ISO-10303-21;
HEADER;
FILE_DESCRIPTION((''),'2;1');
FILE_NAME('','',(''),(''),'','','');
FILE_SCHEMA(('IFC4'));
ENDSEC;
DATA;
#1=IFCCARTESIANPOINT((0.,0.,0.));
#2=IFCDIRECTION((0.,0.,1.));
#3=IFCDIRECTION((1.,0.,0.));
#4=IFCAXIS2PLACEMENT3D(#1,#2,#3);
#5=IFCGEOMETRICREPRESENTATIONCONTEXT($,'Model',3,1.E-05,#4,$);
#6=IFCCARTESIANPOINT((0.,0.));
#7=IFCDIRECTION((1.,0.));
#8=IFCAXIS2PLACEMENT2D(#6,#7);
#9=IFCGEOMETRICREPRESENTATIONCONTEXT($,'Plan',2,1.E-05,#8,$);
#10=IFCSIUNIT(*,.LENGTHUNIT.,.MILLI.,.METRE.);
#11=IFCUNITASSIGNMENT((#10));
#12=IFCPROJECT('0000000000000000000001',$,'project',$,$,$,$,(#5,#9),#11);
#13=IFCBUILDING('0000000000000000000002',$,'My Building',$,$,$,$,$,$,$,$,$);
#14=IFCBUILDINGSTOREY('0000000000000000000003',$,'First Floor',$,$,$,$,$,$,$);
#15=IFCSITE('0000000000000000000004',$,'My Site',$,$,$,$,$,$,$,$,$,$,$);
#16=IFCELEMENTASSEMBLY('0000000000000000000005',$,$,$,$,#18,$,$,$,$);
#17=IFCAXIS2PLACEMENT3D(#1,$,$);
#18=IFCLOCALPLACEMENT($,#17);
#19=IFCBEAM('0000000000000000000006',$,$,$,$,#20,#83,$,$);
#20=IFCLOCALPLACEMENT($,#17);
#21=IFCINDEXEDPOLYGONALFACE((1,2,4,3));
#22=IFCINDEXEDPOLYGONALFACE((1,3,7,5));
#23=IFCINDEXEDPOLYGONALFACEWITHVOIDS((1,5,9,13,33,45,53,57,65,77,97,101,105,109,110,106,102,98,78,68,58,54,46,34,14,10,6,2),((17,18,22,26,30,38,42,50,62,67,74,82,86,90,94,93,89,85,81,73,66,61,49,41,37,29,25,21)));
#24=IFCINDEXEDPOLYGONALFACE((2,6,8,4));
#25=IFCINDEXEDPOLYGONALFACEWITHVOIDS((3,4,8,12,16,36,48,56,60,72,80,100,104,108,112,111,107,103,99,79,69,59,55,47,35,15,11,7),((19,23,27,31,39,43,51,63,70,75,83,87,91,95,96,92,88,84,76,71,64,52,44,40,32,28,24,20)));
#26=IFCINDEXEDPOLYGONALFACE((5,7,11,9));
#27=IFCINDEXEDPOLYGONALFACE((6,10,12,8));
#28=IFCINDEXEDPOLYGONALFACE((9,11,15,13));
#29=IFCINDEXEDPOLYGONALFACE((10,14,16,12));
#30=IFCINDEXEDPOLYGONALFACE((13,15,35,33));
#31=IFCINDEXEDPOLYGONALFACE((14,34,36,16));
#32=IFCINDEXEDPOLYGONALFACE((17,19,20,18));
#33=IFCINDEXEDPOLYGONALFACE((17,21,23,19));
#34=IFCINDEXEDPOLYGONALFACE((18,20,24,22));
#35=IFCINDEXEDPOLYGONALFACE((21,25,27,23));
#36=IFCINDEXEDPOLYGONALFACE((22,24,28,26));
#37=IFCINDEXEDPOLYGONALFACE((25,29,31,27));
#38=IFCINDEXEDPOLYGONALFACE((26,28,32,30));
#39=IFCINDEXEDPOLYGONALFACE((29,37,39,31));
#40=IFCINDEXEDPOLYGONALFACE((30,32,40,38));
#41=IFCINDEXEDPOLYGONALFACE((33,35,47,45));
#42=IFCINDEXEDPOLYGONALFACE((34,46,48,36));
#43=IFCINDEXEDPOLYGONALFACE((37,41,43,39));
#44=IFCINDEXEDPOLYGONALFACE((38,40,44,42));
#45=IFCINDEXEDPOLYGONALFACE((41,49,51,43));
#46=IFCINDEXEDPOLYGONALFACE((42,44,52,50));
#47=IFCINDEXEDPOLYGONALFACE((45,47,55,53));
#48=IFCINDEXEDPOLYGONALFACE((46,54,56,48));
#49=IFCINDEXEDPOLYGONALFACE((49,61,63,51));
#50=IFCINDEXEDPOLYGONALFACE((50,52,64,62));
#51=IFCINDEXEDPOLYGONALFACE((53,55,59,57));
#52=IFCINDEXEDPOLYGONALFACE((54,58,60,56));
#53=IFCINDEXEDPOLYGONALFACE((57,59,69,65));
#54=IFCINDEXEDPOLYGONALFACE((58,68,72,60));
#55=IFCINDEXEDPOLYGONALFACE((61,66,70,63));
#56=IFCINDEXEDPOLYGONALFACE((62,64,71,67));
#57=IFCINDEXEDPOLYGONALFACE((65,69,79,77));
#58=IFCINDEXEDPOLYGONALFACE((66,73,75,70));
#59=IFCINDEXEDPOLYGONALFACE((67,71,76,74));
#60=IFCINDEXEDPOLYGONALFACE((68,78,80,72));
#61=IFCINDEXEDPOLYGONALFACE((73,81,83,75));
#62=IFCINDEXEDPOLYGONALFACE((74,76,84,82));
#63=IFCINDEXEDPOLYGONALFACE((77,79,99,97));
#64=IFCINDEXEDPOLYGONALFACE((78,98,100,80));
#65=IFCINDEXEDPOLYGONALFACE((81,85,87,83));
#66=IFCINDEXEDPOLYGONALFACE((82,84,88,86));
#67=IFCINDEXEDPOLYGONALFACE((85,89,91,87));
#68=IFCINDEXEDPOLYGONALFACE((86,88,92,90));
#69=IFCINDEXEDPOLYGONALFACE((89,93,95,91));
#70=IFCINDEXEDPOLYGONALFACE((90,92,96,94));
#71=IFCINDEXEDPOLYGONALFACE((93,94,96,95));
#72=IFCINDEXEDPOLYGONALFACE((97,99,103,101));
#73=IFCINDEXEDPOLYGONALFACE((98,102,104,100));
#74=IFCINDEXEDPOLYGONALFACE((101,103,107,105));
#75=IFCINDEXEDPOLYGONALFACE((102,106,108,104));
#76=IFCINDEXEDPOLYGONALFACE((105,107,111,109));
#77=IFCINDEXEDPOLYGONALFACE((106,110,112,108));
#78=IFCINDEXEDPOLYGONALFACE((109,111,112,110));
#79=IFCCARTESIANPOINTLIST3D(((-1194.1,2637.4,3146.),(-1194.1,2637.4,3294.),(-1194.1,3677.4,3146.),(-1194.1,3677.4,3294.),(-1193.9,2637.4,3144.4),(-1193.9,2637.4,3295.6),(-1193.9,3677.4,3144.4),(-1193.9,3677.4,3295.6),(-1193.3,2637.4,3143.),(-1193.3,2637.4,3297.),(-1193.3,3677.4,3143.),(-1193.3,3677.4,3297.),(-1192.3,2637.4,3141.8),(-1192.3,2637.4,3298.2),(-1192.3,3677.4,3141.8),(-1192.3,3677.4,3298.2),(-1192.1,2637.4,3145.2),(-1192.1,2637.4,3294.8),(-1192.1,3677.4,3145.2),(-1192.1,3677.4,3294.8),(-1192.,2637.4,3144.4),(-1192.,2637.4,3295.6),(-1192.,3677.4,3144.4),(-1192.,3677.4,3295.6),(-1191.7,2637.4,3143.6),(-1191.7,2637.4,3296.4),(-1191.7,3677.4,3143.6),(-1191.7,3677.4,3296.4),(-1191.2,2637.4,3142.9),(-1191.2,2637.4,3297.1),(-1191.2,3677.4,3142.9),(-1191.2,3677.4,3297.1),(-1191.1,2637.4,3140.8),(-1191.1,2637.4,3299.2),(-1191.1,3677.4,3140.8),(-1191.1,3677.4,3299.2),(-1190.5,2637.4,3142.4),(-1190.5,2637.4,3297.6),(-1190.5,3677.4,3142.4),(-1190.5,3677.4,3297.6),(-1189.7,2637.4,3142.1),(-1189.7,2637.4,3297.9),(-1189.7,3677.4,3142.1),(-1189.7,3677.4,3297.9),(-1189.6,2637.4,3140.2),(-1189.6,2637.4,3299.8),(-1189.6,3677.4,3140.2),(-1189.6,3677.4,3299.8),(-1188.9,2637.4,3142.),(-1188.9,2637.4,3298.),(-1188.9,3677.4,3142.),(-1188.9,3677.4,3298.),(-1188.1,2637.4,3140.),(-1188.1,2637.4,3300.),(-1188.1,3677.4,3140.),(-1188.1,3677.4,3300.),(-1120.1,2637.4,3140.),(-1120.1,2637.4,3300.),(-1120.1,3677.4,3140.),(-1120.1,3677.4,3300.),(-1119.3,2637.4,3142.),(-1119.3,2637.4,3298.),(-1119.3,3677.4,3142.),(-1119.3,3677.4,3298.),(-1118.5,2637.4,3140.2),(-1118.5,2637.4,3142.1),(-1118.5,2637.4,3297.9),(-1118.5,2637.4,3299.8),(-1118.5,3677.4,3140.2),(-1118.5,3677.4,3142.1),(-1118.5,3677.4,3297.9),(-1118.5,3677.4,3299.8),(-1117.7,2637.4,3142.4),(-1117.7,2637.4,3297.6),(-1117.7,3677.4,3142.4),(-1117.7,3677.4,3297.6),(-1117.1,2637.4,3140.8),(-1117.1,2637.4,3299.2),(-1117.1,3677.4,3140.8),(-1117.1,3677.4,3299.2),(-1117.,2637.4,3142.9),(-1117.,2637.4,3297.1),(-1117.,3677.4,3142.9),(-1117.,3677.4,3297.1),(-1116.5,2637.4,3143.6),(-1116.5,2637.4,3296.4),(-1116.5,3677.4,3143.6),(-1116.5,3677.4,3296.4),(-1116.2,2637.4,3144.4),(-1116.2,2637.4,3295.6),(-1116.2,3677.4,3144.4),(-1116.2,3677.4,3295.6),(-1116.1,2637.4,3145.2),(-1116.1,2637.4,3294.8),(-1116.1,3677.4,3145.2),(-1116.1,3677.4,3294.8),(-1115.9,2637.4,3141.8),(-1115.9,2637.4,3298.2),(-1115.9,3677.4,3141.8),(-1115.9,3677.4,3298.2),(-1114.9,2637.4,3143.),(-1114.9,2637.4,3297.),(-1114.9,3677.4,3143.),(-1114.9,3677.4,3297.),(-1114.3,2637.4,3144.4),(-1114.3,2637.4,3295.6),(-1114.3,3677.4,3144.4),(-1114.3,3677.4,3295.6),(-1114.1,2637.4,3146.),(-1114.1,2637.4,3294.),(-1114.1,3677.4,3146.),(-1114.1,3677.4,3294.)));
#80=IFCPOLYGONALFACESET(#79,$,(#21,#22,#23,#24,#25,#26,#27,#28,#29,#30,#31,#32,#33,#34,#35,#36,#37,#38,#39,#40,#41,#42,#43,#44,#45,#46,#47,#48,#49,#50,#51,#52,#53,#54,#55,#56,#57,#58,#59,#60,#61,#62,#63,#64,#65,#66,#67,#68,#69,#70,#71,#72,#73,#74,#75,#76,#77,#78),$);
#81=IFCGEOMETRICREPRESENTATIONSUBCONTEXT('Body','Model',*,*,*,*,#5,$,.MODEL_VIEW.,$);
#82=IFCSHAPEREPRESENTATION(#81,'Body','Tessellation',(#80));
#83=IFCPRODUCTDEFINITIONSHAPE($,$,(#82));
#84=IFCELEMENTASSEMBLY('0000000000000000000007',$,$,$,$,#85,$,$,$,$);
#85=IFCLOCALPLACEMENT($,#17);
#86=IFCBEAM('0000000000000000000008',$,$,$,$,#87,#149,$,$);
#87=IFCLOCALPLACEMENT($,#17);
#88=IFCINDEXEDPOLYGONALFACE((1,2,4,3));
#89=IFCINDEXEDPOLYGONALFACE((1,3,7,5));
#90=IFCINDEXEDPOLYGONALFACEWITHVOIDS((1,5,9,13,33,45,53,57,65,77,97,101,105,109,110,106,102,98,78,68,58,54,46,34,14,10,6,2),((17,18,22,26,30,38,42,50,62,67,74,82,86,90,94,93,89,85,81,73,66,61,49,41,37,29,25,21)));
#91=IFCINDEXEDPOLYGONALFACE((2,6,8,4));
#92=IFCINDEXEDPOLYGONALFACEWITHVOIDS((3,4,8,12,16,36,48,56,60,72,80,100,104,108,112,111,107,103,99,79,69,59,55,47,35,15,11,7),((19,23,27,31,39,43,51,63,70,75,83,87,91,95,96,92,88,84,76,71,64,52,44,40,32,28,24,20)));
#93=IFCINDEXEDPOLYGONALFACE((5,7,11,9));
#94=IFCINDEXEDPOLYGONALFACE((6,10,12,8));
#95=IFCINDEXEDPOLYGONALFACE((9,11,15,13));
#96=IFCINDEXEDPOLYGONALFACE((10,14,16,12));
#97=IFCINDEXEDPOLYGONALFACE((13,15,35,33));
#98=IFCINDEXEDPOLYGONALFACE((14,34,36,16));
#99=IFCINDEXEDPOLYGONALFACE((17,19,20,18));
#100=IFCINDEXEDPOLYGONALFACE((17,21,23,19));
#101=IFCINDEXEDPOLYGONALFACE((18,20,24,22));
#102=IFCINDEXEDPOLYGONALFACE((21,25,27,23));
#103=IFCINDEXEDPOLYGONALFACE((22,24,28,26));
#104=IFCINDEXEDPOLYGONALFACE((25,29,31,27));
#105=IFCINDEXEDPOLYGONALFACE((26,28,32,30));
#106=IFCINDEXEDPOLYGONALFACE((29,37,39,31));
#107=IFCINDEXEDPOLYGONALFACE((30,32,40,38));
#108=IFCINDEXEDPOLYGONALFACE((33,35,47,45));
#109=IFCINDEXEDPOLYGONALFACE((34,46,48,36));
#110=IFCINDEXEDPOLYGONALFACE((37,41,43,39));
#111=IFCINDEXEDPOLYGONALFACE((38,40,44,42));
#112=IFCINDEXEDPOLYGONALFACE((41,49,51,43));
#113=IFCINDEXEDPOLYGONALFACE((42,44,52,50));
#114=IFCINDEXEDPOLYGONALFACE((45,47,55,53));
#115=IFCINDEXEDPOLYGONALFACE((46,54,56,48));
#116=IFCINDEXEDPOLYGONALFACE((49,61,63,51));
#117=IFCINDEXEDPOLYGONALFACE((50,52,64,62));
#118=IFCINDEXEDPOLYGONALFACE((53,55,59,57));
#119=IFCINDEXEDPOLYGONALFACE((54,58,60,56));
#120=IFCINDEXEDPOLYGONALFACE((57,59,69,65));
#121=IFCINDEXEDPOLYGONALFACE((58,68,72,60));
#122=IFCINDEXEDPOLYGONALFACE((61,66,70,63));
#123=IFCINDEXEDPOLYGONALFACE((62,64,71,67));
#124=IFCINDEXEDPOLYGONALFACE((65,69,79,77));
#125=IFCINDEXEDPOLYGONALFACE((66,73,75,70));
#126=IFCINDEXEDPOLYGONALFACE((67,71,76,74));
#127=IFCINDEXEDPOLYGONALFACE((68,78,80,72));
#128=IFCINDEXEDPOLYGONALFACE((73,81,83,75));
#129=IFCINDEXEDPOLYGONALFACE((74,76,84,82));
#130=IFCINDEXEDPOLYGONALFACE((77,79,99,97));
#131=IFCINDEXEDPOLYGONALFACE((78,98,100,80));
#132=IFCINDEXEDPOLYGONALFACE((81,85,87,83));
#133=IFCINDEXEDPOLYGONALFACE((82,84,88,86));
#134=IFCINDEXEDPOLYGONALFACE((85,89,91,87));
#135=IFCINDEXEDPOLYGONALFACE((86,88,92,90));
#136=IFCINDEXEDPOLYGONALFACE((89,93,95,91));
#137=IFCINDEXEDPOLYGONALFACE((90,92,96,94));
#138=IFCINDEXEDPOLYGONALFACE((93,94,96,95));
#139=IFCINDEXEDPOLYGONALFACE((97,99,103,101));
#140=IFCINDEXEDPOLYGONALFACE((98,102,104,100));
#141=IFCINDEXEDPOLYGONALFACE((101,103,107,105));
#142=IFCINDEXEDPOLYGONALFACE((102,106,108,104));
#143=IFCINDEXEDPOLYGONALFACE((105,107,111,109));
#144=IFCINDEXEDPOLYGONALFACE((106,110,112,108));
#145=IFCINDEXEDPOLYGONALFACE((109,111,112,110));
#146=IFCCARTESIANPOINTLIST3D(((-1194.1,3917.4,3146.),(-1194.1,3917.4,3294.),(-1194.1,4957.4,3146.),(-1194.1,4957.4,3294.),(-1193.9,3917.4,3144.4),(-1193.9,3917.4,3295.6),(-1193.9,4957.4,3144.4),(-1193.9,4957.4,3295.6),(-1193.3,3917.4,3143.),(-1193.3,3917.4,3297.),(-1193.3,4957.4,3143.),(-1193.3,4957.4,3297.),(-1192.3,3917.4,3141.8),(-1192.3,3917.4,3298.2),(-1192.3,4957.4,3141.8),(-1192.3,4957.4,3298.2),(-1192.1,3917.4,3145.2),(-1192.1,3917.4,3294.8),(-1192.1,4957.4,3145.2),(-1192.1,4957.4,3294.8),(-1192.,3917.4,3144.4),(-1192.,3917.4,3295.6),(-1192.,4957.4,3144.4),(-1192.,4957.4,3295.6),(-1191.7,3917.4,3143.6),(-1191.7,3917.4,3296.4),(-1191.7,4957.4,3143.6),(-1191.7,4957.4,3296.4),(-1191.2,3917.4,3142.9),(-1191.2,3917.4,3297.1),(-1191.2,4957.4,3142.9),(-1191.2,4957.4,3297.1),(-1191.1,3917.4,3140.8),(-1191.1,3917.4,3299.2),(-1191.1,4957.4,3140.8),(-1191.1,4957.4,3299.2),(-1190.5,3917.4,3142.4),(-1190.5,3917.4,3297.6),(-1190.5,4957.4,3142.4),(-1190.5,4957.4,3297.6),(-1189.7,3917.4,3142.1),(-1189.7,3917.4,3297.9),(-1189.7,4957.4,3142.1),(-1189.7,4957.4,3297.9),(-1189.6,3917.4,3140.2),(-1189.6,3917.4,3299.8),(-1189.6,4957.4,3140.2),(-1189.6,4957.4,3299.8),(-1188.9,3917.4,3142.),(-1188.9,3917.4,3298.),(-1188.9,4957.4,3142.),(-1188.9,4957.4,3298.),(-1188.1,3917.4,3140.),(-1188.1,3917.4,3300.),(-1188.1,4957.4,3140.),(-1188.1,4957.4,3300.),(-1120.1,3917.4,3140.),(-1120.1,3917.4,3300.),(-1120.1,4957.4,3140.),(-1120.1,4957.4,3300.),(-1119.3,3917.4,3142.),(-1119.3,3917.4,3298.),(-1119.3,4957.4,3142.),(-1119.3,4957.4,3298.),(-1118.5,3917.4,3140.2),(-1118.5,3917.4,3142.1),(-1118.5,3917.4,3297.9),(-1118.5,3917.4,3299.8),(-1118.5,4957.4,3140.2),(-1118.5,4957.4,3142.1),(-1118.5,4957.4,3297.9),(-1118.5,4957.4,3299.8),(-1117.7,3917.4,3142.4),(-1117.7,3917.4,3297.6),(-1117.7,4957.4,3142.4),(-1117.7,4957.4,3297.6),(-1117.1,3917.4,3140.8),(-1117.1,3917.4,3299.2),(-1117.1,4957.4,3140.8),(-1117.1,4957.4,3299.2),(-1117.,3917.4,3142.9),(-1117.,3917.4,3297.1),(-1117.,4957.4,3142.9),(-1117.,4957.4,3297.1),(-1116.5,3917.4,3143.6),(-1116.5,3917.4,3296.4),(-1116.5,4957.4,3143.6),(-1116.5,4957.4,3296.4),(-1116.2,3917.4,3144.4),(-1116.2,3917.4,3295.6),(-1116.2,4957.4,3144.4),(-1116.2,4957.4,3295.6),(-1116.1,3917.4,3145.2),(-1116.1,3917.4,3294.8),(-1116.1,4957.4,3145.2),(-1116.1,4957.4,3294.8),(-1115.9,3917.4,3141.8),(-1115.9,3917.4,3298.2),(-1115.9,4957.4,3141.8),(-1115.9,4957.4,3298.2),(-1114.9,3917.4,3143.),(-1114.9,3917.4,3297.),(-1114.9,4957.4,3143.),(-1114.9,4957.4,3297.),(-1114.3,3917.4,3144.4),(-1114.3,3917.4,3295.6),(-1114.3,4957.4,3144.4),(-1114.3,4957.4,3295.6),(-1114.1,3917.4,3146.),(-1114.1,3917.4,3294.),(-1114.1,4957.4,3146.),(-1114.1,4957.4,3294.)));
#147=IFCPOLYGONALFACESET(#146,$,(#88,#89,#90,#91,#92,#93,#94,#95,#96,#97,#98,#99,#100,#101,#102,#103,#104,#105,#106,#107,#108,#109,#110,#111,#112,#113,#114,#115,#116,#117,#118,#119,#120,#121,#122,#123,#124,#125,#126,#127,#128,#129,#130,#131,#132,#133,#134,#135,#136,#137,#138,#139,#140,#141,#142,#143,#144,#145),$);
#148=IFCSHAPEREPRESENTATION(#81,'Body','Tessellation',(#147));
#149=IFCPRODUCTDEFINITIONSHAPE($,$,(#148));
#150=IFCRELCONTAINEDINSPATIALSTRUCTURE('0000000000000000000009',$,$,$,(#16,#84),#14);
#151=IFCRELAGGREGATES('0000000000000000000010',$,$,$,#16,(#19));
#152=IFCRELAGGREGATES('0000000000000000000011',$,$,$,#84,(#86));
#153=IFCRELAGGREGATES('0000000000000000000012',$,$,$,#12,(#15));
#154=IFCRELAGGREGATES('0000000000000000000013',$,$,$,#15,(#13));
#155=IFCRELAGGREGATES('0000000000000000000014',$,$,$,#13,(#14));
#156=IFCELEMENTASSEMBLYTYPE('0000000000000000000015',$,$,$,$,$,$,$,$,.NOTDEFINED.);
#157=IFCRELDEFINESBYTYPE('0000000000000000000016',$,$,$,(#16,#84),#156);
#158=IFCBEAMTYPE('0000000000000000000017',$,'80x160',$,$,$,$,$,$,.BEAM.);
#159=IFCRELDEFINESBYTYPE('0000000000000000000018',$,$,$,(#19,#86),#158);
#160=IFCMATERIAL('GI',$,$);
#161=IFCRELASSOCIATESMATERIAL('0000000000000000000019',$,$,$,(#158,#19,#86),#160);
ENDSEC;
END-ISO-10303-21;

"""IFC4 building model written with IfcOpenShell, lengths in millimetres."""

from ifc_helpers import new_model, si_unit, frame, origin_with_axes, origin_2d_with_axis, place, context, subcontext, project, spatial, hollow_rectangle, extrude, material, material_profile, profile_set, profile_usage, type_object, element, aggregate, save


model = new_model("IFC4")

# Units and contexts
model_context = context("Model", 3, precision=1e-05, world=origin_with_axes())
plan_context = context("Plan", 2, precision=1e-05, world=origin_2d_with_axis())
body_context = subcontext(model_context, "Body", "Model", "MODEL_VIEW")
ifc_project = project(units=[si_unit("LENGTHUNIT", "METRE", prefix="MILLI")], contexts=[model_context, plan_context])

# Site, building, storey
site = spatial("IfcSite", under=ifc_project, Name="My Site")
building = spatial("IfcBuilding", under=site, Name="My Building")
storey = spatial("IfcBuildingStorey", under=building, Name="First Floor")

# Element assemblies, beams
element_assembly_type = type_object("IfcElementAssemblyType", PredefinedType="NOTDEFINED")
ifc_material = material(Name="GI")
ifc_material_profile = material_profile(ifc_material, hollow_rectangle(XDim=80.0, YDim=160.0, WallThickness=2.0, InnerFilletRadius=3.2, OuterFilletRadius=6.0))
ifc_profile_set = profile_set([ifc_material_profile], Name="80x160 GI Rectangular Hollow")
beam_type = type_object("IfcBeamType", Name="80x160", PredefinedType="BEAM", material=ifc_profile_set)
assembly_1_placement = place(None, frame((-1154.1, 2557.4, 3220.0), z_axis=(0.0, 1.0, 0.0), x_axis=(1.0, 0.0, 0.0)))
assembly_1 = element("IfcElementAssembly", 1, at=assembly_1_placement, inside=storey, type_object=element_assembly_type)
ifc_profile_usage_1 = profile_usage(ifc_profile_set)
beam_1_placement = place(assembly_1_placement, frame((0.0, 0.0, 80.0), z_axis=(0.0, 0.0, 1.0), x_axis=(1.0, 0.0, 0.0)))
beam_1 = element("IfcBeam", 2, at=beam_1_placement, type_object=beam_type, material=ifc_profile_usage_1, context=body_context, shape_type="SweptSolid", body=[
    extrude(hollow_rectangle(XDim=80.0, YDim=160.0, WallThickness=2.0, InnerFilletRadius=3.2, OuterFilletRadius=6.0), origin_with_axes(), (0.0, 0.0, 1.0), 1040.0),
])
aggregate(assembly_1, [beam_1])
assembly_2_placement = place(None, frame((-1154.1, 3837.4, 3220.0), z_axis=(0.0, 1.0, 0.0), x_axis=(1.0, 0.0, 0.0)))
assembly_2 = element("IfcElementAssembly", 3, at=assembly_2_placement, inside=storey, type_object=element_assembly_type)
ifc_profile_usage_2 = profile_usage(ifc_profile_set)
beam_2_placement = place(assembly_2_placement, frame((0.0, 0.0, 80.0), z_axis=(0.0, 0.0, 1.0), x_axis=(1.0, 0.0, 0.0)))
beam_2 = element("IfcBeam", 4, at=beam_2_placement, type_object=beam_type, material=ifc_profile_usage_2, context=body_context, shape_type="SweptSolid", body=[
    extrude(hollow_rectangle(XDim=80.0, YDim=160.0, WallThickness=2.0, InnerFilletRadius=3.2, OuterFilletRadius=6.0), origin_with_axes(), (0.0, 0.0, 1.0), 1040.0),
])
aggregate(assembly_2, [beam_2])

save(model, "model.ifc")
